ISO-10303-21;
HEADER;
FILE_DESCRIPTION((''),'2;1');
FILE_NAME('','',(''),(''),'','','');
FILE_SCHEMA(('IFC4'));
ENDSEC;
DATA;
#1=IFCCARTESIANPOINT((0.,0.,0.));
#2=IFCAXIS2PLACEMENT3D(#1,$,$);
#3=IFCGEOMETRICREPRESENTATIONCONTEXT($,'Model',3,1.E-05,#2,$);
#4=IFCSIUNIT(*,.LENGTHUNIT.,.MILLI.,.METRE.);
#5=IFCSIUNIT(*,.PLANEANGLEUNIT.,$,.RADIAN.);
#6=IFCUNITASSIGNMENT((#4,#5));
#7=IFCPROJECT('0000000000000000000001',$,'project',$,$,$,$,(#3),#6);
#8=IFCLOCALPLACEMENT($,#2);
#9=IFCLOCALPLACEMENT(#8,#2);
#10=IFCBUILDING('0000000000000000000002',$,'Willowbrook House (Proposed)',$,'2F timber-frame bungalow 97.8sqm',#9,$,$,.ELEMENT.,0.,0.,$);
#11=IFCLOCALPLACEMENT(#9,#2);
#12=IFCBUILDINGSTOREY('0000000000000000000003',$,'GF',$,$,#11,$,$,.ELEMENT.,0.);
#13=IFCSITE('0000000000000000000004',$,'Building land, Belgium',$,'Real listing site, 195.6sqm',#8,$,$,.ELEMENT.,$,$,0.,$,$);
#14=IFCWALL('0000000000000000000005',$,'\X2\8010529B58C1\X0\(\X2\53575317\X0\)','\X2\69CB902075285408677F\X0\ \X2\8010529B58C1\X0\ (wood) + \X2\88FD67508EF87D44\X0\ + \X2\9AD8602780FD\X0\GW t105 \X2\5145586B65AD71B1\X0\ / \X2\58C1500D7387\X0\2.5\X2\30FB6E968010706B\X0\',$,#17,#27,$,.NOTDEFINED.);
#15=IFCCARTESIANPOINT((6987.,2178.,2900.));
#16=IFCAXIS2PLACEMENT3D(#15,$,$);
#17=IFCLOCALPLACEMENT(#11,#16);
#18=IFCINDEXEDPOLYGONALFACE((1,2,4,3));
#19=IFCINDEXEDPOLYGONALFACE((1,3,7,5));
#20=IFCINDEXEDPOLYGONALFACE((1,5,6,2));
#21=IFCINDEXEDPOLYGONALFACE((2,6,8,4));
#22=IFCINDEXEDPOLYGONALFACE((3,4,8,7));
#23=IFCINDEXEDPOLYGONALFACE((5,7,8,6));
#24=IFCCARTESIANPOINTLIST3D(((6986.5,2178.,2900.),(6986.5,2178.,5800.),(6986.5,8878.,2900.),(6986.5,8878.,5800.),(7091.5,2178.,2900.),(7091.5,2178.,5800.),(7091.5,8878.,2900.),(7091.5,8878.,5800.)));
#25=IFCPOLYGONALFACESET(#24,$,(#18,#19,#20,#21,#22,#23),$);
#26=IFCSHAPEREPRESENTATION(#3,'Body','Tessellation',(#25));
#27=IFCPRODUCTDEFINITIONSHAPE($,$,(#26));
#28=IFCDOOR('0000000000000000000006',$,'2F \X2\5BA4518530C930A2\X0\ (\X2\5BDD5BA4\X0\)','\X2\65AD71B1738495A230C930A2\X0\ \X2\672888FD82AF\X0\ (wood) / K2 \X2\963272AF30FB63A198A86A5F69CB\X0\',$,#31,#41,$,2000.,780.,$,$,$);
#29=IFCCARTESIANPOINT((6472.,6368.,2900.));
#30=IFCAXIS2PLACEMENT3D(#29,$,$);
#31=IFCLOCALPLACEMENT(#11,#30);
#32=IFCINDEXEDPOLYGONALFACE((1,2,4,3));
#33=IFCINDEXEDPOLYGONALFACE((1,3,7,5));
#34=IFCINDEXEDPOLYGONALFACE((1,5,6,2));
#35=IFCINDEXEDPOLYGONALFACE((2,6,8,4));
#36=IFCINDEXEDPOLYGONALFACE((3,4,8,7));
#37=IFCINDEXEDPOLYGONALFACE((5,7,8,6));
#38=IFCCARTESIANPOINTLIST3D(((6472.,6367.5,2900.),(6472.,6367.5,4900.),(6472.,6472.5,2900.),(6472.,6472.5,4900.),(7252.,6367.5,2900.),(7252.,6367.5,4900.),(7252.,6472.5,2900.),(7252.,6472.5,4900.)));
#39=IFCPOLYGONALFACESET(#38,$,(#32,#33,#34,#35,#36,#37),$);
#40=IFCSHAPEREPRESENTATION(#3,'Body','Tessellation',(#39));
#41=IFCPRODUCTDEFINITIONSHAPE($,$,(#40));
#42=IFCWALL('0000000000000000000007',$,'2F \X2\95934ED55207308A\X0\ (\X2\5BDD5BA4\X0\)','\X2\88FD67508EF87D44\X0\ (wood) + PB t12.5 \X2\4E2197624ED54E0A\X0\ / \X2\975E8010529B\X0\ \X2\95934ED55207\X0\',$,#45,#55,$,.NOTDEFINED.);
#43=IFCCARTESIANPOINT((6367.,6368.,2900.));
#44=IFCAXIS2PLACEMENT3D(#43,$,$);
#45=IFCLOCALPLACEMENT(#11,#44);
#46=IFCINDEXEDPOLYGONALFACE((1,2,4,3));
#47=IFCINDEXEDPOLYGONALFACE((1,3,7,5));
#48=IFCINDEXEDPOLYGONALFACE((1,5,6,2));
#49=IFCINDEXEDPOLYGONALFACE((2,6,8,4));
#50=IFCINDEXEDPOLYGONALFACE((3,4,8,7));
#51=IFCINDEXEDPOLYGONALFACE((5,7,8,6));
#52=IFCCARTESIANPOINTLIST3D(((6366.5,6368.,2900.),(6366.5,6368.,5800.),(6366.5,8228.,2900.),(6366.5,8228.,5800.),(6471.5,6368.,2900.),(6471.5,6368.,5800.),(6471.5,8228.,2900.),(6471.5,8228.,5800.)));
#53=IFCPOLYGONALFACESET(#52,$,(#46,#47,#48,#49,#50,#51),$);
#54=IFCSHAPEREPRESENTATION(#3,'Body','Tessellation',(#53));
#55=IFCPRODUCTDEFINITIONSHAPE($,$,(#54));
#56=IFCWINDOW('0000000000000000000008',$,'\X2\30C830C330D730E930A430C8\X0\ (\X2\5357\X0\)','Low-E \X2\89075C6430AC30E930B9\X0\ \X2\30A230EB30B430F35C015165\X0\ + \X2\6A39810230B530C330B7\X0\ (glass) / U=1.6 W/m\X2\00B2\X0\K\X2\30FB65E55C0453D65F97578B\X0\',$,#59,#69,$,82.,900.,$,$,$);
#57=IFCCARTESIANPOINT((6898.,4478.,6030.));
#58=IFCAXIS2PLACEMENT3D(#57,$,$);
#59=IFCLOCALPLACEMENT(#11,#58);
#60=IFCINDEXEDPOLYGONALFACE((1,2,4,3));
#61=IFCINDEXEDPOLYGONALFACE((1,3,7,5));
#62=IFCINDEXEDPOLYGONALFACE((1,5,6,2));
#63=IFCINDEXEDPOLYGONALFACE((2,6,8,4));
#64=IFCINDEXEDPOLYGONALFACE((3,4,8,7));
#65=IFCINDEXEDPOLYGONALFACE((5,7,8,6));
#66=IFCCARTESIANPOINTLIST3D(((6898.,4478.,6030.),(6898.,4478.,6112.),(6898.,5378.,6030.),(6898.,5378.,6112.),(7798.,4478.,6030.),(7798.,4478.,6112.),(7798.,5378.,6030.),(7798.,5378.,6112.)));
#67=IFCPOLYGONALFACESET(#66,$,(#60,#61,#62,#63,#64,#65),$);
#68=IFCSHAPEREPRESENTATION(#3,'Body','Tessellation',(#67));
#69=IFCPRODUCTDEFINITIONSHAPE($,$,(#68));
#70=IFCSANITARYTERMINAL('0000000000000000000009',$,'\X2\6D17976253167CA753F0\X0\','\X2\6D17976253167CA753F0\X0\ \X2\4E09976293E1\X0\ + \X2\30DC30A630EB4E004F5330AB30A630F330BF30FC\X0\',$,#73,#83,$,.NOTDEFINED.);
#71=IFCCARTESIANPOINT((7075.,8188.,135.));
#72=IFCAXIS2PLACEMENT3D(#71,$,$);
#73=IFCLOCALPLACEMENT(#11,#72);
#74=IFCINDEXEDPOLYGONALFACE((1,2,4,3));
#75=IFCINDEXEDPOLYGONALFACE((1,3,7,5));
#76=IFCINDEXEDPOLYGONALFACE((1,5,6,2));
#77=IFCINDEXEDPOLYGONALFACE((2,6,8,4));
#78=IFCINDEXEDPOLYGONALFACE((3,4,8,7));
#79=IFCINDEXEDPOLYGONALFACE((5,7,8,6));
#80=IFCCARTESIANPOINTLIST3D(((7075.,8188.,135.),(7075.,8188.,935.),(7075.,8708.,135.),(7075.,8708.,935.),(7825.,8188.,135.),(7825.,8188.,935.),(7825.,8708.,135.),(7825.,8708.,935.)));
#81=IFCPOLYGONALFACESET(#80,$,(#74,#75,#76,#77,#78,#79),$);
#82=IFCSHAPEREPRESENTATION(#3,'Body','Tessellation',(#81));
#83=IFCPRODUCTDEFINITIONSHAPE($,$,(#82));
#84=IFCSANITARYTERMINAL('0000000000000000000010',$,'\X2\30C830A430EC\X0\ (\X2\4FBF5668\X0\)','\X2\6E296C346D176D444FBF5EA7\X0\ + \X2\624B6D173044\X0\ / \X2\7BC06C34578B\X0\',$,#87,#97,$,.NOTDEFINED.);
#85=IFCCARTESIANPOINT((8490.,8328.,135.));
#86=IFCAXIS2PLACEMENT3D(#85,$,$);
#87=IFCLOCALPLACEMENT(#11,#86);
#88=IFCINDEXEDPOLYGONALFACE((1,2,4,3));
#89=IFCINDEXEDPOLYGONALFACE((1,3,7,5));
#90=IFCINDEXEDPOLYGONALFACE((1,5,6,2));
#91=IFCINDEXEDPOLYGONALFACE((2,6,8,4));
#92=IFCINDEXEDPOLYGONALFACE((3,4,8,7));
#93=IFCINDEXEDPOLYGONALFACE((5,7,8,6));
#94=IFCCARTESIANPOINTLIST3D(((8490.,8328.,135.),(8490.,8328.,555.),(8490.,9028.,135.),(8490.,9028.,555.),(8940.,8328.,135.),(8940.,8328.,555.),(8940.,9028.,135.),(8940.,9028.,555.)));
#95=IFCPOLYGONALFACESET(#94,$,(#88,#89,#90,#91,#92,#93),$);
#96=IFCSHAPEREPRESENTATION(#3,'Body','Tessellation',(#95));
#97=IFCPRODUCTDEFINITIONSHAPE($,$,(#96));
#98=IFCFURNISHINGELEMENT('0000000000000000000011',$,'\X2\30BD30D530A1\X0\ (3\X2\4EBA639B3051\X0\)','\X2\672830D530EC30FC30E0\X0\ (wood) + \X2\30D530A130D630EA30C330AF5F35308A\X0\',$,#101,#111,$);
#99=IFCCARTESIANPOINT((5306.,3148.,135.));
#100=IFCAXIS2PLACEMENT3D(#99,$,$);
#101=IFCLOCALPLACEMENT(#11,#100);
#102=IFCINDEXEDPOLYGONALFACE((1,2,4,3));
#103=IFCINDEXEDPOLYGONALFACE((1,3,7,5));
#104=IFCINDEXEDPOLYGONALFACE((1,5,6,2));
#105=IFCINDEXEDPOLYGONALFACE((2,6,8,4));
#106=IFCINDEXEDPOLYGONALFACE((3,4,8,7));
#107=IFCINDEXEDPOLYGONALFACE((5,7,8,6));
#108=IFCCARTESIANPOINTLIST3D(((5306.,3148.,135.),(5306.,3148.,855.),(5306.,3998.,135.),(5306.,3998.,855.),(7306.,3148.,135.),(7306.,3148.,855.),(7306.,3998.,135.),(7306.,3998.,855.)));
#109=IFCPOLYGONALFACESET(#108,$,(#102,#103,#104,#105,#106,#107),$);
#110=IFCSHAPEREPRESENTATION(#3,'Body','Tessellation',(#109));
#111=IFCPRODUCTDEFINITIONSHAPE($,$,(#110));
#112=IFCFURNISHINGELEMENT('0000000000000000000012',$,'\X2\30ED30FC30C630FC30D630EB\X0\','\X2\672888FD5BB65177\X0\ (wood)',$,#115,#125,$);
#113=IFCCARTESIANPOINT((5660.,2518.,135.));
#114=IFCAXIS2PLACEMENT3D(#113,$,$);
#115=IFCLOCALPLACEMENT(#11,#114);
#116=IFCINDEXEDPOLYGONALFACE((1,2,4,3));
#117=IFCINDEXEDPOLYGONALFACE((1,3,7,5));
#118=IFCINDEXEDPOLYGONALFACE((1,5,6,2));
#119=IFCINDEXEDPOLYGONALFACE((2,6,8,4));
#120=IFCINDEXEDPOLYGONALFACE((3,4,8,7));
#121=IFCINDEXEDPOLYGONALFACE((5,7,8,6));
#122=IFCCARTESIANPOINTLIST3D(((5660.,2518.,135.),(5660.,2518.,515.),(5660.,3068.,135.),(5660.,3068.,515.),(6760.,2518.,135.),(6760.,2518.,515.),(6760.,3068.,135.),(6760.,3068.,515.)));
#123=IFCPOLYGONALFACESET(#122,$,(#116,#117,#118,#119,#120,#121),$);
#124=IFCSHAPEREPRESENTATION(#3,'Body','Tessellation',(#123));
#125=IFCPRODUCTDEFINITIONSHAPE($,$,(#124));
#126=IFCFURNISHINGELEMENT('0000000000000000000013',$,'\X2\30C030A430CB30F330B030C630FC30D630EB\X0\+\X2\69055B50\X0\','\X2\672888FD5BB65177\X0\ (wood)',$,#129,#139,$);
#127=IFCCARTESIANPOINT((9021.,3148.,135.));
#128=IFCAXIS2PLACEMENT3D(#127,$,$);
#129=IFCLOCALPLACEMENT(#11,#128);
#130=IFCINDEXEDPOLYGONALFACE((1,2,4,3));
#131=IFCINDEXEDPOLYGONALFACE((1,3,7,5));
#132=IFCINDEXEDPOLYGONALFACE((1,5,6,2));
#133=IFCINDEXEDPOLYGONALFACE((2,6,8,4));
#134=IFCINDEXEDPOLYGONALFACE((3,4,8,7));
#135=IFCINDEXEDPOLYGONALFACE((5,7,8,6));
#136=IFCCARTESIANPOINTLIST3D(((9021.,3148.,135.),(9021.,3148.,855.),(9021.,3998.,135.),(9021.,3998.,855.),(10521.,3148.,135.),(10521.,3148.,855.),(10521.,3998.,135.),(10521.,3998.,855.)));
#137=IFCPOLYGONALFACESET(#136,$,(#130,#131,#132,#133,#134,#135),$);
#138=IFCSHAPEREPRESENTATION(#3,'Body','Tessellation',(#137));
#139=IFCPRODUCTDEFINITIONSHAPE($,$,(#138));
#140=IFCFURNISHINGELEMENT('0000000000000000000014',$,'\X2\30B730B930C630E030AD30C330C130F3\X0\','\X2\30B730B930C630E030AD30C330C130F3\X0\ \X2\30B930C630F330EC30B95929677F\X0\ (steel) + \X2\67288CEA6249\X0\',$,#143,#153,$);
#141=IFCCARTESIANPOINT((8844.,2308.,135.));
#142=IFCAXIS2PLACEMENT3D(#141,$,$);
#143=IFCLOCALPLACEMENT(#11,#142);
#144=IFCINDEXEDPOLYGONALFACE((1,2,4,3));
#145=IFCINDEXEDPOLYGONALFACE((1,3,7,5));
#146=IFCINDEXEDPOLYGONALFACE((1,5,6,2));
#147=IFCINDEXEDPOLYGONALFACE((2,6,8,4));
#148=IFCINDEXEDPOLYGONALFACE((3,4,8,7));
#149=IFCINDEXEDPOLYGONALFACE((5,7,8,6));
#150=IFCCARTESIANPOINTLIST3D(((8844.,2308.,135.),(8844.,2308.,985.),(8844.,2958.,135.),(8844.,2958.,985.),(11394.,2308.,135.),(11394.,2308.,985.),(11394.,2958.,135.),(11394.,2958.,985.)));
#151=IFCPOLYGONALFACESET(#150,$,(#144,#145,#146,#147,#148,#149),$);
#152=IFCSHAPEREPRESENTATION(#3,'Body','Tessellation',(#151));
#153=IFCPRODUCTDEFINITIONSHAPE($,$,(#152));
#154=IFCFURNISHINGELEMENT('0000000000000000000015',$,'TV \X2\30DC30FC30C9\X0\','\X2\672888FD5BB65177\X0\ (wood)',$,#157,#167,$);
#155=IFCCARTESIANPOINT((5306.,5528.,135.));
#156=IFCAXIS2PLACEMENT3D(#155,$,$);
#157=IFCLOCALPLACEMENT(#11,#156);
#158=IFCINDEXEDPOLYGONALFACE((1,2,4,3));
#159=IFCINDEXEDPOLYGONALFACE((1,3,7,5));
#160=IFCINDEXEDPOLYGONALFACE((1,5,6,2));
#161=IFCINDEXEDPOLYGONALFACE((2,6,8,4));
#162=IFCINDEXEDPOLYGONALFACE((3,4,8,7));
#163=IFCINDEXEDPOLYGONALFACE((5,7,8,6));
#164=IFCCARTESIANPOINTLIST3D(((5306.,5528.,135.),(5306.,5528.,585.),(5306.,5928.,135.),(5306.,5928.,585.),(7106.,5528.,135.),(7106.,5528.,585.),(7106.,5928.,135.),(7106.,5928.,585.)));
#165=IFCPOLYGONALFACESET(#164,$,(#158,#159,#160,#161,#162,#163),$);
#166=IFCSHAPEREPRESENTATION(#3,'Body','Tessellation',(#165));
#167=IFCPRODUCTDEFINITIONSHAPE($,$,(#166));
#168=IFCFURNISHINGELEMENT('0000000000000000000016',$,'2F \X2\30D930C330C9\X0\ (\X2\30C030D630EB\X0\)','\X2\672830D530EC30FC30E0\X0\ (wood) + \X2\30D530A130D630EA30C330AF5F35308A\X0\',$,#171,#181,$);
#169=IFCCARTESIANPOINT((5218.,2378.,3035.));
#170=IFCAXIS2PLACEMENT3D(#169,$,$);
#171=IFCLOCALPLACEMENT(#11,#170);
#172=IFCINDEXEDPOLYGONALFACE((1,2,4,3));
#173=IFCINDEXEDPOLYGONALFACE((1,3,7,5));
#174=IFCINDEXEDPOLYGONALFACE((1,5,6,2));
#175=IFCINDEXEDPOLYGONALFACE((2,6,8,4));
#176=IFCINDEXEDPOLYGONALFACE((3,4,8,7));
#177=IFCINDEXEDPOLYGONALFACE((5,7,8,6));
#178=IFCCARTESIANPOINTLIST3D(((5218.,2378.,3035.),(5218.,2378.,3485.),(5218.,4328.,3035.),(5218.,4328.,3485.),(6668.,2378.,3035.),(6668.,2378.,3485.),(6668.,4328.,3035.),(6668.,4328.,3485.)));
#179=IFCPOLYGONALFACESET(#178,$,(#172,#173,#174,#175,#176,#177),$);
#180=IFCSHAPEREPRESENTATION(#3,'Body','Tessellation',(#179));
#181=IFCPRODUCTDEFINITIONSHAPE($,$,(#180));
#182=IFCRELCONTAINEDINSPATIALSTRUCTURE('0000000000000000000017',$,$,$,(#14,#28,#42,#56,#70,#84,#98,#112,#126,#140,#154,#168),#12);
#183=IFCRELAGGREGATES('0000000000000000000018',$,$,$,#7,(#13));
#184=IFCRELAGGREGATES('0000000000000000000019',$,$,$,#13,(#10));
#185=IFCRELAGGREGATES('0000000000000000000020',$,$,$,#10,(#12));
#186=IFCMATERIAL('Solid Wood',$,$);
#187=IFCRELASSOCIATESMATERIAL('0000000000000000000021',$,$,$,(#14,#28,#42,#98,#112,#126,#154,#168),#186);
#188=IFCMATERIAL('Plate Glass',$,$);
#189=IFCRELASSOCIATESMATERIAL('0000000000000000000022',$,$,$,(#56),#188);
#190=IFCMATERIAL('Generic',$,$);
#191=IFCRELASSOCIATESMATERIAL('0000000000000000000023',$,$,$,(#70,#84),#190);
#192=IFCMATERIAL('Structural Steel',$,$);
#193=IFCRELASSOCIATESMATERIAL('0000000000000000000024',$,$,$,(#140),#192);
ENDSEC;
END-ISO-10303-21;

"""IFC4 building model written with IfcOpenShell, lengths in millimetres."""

from ifc_helpers import new_model, si_unit, frame, frame_2d, origin, place, context, project, spatial, rectangle, extrude, material, element, fill, save


model = new_model("IFC4")

# Units and contexts
model_context = context("Model", 3, precision=1e-05, world=origin())
ifc_project = project(units=[si_unit("LENGTHUNIT", "METRE", prefix="MILLI"), si_unit("PLANEANGLEUNIT", "RADIAN")], contexts=[model_context])

# Site, building, storey
site_placement = place(None, origin())
site = spatial("IfcSite", under=ifc_project, at=site_placement, Name="Building land, Belgium", ObjectType="Real listing site, 195.6sqm", CompositionType="ELEMENT", RefElevation=0.0)
building_placement = place(site_placement, origin())
building = spatial("IfcBuilding", under=site, at=building_placement, Name="Willowbrook House (Proposed)", ObjectType="2F timber-frame bungalow 97.8sqm", CompositionType="ELEMENT", ElevationOfRefHeight=0.0, ElevationOfTerrain=0.0)
storey_placement = place(building_placement, origin())
storey = spatial("IfcBuildingStorey", under=building, at=storey_placement, Name="GF", CompositionType="ELEMENT", Elevation=0.0)

# Shared definitions
ifc_material_1 = material(Name="Solid Wood")

# Wall, opening, door
wall_1_placement = place(storey_placement, frame((6987.0, 2178.0, 2900.0)))
wall_1 = element("IfcWall", 1, at=wall_1_placement, inside=storey, material=ifc_material_1, Name="耐力壁(南北)", Description="構造用合板 耐力壁 (wood) + 製材軸組 + 高性能GW t105 充填断熱 / 壁倍率2.5・準耐火", PredefinedType="NOTDEFINED", context=model_context, shape_type="SweptSolid", body=[
    extrude(rectangle(XDim=105.0, YDim=6700.0, at=frame_2d((52.0, 3350.0))), frame((6987.0, 2178.0, 2900.0)), (0.0, 0.0, 1.0), 2900.0),
])
opening_1_placement = place(storey_placement, frame((6472.0, 6368.0, 2900.0)))
opening_1 = element("IfcOpeningElement", 2, at=opening_1_placement, cuts=wall_1, PredefinedType="NOTDEFINED", context=model_context, shape_type="SweptSolid", body=[
    extrude(rectangle(XDim=780.0, YDim=105.0, at=frame_2d((390.0, 52.0))), frame((6472.0, 6368.0, 2900.0)), (0.0, 0.0, 1.0), 2000.0),
])
door_1_placement = place(storey_placement, frame((6472.0, 6368.0, 2900.0)))
door_1 = element("IfcDoor", 3, at=door_1_placement, inside=storey, material=ifc_material_1, Name="2F 室内ドア (寝室)", Description="断熱玄関ドア 木製芯 (wood) / K2 防犯・採風機構", OverallHeight=2000.0, OverallWidth=780.0, context=model_context, shape_type="SweptSolid", body=[
    extrude(rectangle(XDim=780.0, YDim=105.0, at=frame_2d((390.0, 52.0))), frame((6472.0, 6368.0, 2900.0)), (0.0, 0.0, 1.0), 2000.0),
])
fill(opening_1, door_1)

# Wall
wall_2_placement = place(storey_placement, frame((6367.0, 6368.0, 2900.0)))
element("IfcWall", 4, at=wall_2_placement, inside=storey, material=ifc_material_1, Name="2F 間仕切り (寝室)", Description="製材軸組 (wood) + PB t12.5 両面仕上 / 非耐力 間仕切", PredefinedType="NOTDEFINED", context=model_context, shape_type="SweptSolid", body=[
    extrude(rectangle(XDim=105.0, YDim=1860.0, at=frame_2d((52.0, 930.0))), frame((6367.0, 6368.0, 2900.0)), (0.0, 0.0, 1.0), 2900.0),
])

# Window
ifc_material_2 = material(Name="Plate Glass")
window_placement = place(storey_placement, frame((6898.0, 4478.0, 6030.0)))
element("IfcWindow", 5, at=window_placement, inside=storey, material=ifc_material_2, Name="トップライト (南)", Description="Low-E 複層ガラス アルゴン封入 + 樹脂サッシ (glass) / U=1.6 W/m²K・日射取得型", OverallHeight=82.0, OverallWidth=900.0, context=model_context, shape_type="SweptSolid", body=[
    extrude(rectangle(XDim=900.0, YDim=900.0, at=frame_2d((450.0, 450.0))), frame((6898.0, 4478.0, 6030.0)), (0.0, 0.0, 1.0), 82.0),
])

# Sanitary terminals
ifc_material_3 = material(Name="Generic")
sanitary_terminal_1_placement = place(storey_placement, frame((7075.0, 8188.0, 135.0)))
element("IfcSanitaryTerminal", 6, at=sanitary_terminal_1_placement, inside=storey, material=ifc_material_3, Name="洗面化粧台", Description="洗面化粧台 三面鏡 + ボウル一体カウンター", PredefinedType="NOTDEFINED", context=model_context, shape_type="SweptSolid", body=[
    extrude(rectangle(XDim=750.0, YDim=520.0, at=frame_2d((375.0, 260.0))), frame((7075.0, 8188.0, 135.0)), (0.0, 0.0, 1.0), 800.0),
])
sanitary_terminal_2_placement = place(storey_placement, frame((8490.0, 8328.0, 135.0)))
element("IfcSanitaryTerminal", 7, at=sanitary_terminal_2_placement, inside=storey, material=ifc_material_3, Name="トイレ (便器)", Description="温水洗浄便座 + 手洗い / 節水型", PredefinedType="NOTDEFINED", context=model_context, shape_type="SweptSolid", body=[
    extrude(rectangle(XDim=450.0, YDim=700.0, at=frame_2d((225.0, 350.0))), frame((8490.0, 8328.0, 135.0)), (0.0, 0.0, 1.0), 420.0),
])

# Furnishing elements
furnishing_1_placement = place(storey_placement, frame((5306.0, 3148.0, 135.0)))
element("IfcFurnishingElement", 8, at=furnishing_1_placement, inside=storey, material=ifc_material_1, Name="ソファ (3人掛け)", Description="木フレーム (wood) + ファブリック張り", context=model_context, shape_type="SweptSolid", body=[
    extrude(rectangle(XDim=2000.0, YDim=850.0, at=frame_2d((1000.0, 425.0))), frame((5306.0, 3148.0, 135.0)), (0.0, 0.0, 1.0), 720.0),
])
furnishing_2_placement = place(storey_placement, frame((5660.0, 2518.0, 135.0)))
element("IfcFurnishingElement", 9, at=furnishing_2_placement, inside=storey, material=ifc_material_1, Name="ローテーブル", Description="木製家具 (wood)", context=model_context, shape_type="SweptSolid", body=[
    extrude(rectangle(XDim=1100.0, YDim=550.0, at=frame_2d((550.0, 275.0))), frame((5660.0, 2518.0, 135.0)), (0.0, 0.0, 1.0), 380.0),
])
furnishing_3_placement = place(storey_placement, frame((9021.0, 3148.0, 135.0)))
element("IfcFurnishingElement", 10, at=furnishing_3_placement, inside=storey, material=ifc_material_1, Name="ダイニングテーブル+椅子", Description="木製家具 (wood)", context=model_context, shape_type="SweptSolid", body=[
    extrude(rectangle(XDim=1500.0, YDim=850.0, at=frame_2d((750.0, 425.0))), frame((9021.0, 3148.0, 135.0)), (0.0, 0.0, 1.0), 720.0),
])
ifc_material_4 = material(Name="Structural Steel")
furnishing_4_placement = place(storey_placement, frame((8844.0, 2308.0, 135.0)))
element("IfcFurnishingElement", 11, at=furnishing_4_placement, inside=storey, material=ifc_material_4, Name="システムキッチン", Description="システムキッチン ステンレス天板 (steel) + 木質扉", context=model_context, shape_type="SweptSolid", body=[
    extrude(rectangle(XDim=2550.0, YDim=650.0, at=frame_2d((1275.0, 325.0))), frame((8844.0, 2308.0, 135.0)), (0.0, 0.0, 1.0), 850.0),
])
furnishing_5_placement = place(storey_placement, frame((5306.0, 5528.0, 135.0)))
element("IfcFurnishingElement", 12, at=furnishing_5_placement, inside=storey, material=ifc_material_1, Name="TV ボード", Description="木製家具 (wood)", context=model_context, shape_type="SweptSolid", body=[
    extrude(rectangle(XDim=1800.0, YDim=400.0, at=frame_2d((900.0, 200.0))), frame((5306.0, 5528.0, 135.0)), (0.0, 0.0, 1.0), 450.0),
])
furnishing_6_placement = place(storey_placement, frame((5218.0, 2378.0, 3035.0)))
element("IfcFurnishingElement", 13, at=furnishing_6_placement, inside=storey, material=ifc_material_1, Name="2F ベッド (ダブル)", Description="木フレーム (wood) + ファブリック張り", context=model_context, shape_type="SweptSolid", body=[
    extrude(rectangle(XDim=1450.0, YDim=1950.0, at=frame_2d((725.0, 975.0))), frame((5218.0, 2378.0, 3035.0)), (0.0, 0.0, 1.0), 450.0),
])

save(model, "model.ifc")
